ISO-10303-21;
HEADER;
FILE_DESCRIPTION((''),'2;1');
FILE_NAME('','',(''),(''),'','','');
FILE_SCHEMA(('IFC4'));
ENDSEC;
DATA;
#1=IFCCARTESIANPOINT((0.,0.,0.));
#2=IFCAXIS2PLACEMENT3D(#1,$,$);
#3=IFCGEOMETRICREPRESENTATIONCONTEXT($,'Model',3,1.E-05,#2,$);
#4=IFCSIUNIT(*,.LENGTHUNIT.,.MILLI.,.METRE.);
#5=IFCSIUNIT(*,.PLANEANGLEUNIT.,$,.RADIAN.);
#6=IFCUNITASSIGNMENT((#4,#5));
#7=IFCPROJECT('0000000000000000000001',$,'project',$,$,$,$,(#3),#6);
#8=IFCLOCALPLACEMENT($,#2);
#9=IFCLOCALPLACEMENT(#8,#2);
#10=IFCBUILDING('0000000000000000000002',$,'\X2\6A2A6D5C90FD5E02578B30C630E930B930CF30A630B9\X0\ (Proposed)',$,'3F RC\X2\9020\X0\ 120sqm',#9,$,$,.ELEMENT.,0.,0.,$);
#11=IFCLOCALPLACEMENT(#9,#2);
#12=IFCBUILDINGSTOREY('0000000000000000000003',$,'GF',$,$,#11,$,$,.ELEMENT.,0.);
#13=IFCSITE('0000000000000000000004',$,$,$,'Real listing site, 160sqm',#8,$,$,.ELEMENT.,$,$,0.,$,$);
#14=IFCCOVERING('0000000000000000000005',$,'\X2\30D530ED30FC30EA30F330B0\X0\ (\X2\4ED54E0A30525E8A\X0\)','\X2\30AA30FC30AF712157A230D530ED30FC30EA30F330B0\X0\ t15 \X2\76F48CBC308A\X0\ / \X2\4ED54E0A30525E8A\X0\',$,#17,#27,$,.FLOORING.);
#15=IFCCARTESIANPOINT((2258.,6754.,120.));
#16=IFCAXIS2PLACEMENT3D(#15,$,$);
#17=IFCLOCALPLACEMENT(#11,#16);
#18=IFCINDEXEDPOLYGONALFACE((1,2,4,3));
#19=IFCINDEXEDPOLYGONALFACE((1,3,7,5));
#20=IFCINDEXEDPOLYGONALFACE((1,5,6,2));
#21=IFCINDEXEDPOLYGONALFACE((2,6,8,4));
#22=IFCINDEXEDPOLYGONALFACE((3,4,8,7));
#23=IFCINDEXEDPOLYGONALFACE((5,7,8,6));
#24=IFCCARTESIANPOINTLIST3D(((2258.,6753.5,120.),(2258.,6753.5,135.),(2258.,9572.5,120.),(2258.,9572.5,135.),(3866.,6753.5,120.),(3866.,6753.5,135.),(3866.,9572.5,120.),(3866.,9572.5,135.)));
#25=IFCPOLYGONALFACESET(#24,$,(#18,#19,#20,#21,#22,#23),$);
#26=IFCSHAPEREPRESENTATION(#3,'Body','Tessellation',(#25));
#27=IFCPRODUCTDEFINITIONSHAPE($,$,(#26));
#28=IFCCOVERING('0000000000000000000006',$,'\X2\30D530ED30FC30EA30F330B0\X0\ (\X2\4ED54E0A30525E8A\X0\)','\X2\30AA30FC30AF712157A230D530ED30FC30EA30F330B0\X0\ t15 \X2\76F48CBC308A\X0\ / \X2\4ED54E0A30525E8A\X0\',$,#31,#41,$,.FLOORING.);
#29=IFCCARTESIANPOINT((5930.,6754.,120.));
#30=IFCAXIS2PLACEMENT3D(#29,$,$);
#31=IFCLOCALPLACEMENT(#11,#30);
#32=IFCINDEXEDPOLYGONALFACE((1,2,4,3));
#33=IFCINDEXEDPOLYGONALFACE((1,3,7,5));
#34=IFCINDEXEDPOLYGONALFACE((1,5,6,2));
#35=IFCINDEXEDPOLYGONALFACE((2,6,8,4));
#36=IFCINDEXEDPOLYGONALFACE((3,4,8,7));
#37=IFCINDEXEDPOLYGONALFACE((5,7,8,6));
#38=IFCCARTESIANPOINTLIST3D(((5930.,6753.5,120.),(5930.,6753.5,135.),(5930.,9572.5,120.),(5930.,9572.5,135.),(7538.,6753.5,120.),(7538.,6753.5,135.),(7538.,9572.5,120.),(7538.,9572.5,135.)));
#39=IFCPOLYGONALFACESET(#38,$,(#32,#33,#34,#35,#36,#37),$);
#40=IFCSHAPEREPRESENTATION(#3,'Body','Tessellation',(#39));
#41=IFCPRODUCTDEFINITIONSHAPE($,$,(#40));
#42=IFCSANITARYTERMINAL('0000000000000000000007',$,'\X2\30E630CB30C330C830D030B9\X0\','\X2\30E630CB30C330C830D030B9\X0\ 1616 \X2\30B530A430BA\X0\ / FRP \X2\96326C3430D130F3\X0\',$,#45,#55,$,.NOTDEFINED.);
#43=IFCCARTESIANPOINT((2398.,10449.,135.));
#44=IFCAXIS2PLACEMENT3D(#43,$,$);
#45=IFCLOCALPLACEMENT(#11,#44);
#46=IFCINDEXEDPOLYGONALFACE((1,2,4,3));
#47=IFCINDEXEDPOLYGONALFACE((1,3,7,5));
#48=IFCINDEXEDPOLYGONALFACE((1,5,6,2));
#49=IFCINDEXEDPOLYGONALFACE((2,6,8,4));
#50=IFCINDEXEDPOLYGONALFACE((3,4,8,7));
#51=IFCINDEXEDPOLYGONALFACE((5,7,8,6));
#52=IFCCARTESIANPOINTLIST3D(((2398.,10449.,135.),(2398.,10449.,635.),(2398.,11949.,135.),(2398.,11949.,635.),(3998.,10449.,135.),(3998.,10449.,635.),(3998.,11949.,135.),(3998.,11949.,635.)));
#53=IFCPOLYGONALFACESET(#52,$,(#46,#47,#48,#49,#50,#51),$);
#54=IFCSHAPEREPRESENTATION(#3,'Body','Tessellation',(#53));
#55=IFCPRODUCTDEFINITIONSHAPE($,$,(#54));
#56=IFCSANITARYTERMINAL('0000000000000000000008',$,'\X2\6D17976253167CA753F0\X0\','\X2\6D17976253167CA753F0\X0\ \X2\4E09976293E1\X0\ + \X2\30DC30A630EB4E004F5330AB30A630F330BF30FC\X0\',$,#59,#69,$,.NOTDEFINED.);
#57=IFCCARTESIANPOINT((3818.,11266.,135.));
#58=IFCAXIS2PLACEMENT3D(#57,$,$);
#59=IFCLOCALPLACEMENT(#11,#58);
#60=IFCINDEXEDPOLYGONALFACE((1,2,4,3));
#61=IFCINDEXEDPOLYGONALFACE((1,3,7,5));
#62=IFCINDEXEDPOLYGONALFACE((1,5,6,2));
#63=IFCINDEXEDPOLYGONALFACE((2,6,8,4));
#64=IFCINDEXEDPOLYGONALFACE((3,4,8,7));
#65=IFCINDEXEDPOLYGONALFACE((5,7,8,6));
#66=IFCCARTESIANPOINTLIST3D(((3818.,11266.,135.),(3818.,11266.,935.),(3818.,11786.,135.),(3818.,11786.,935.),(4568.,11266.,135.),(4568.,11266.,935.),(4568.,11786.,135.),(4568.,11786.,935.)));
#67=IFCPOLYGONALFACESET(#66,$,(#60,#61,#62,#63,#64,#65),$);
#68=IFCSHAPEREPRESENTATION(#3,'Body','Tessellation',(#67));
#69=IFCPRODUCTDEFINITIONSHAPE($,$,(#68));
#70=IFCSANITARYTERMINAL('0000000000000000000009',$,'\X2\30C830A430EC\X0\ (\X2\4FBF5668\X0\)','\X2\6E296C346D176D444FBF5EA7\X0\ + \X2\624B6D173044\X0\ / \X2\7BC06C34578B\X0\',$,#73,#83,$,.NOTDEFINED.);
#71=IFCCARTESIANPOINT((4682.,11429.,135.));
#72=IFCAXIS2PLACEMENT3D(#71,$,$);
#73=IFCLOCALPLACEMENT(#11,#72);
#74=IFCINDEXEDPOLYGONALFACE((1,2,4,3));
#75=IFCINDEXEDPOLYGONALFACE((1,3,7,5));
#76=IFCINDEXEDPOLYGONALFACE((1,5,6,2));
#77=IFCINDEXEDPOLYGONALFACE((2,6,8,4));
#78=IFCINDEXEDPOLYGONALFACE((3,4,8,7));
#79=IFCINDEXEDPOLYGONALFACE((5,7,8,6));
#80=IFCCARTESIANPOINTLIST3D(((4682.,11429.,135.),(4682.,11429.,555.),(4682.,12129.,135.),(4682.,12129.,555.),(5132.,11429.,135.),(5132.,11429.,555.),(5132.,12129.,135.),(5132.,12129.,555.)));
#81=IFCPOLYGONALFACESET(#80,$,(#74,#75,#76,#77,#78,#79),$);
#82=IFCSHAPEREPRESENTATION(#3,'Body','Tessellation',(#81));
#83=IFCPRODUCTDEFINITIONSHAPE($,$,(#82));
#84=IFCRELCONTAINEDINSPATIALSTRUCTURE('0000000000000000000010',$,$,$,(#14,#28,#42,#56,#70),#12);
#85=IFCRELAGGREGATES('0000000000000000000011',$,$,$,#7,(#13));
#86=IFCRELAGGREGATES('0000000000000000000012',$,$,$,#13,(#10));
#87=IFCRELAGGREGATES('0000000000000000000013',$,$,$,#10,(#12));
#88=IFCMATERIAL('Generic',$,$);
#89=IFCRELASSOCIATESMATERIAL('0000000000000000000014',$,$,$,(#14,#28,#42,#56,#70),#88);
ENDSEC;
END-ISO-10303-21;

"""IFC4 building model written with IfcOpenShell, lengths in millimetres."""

from ifc_helpers import new_model, si_unit, frame, frame_2d, origin, place, context, project, spatial, rectangle, extrude, material, element, save


model = new_model("IFC4")

# Units and contexts
model_context = context("Model", 3, precision=1e-05, world=origin())
ifc_project = project(units=[si_unit("LENGTHUNIT", "METRE", prefix="MILLI"), si_unit("PLANEANGLEUNIT", "RADIAN")], contexts=[model_context])

# Site, building, storey
site_placement = place(None, origin())
site = spatial("IfcSite", under=ifc_project, at=site_placement, ObjectType="Real listing site, 160sqm", CompositionType="ELEMENT", RefElevation=0.0)
building_placement = place(site_placement, origin())
building = spatial("IfcBuilding", under=site, at=building_placement, Name="横浜都市型テラスハウス (Proposed)", ObjectType="3F RC造 120sqm", CompositionType="ELEMENT", ElevationOfRefHeight=0.0, ElevationOfTerrain=0.0)
storey_placement = place(building_placement, origin())
storey = spatial("IfcBuildingStorey", under=building, at=storey_placement, Name="GF", CompositionType="ELEMENT", Elevation=0.0)

# Coverings
ifc_material_1 = material(Name="Generic")
covering_1_placement = place(storey_placement, frame((2258.0, 6754.0, 120.0)))
element("IfcCovering", 1, at=covering_1_placement, inside=storey, material=ifc_material_1, Name="フローリング (仕上げ床)", Description="オーク無垢フローリング t15 直貼り / 仕上げ床", PredefinedType="FLOORING", context=model_context, shape_type="SweptSolid", body=[
    extrude(rectangle(XDim=1608.0, YDim=2819.0, at=frame_2d((804.0, 1409.0))), frame((2258.0, 6754.0, 120.0)), (0.0, 0.0, 1.0), 15.0),
])
covering_2_placement = place(storey_placement, frame((5930.0, 6754.0, 120.0)))
element("IfcCovering", 2, at=covering_2_placement, inside=storey, material=ifc_material_1, Name="フローリング (仕上げ床)", Description="オーク無垢フローリング t15 直貼り / 仕上げ床", PredefinedType="FLOORING", context=model_context, shape_type="SweptSolid", body=[
    extrude(rectangle(XDim=1608.0, YDim=2819.0, at=frame_2d((804.0, 1409.0))), frame((5930.0, 6754.0, 120.0)), (0.0, 0.0, 1.0), 15.0),
])

# Sanitary terminals
sanitary_terminal_1_placement = place(storey_placement, frame((2398.0, 10449.0, 135.0)))
element("IfcSanitaryTerminal", 3, at=sanitary_terminal_1_placement, inside=storey, material=ifc_material_1, Name="ユニットバス", Description="ユニットバス 1616 サイズ / FRP 防水パン", PredefinedType="NOTDEFINED", context=model_context, shape_type="SweptSolid", body=[
    extrude(rectangle(XDim=1600.0, YDim=1500.0, at=frame_2d((800.0, 750.0))), frame((2398.0, 10449.0, 135.0)), (0.0, 0.0, 1.0), 500.0),
])
sanitary_terminal_2_placement = place(storey_placement, frame((3818.0, 11266.0, 135.0)))
element("IfcSanitaryTerminal", 4, at=sanitary_terminal_2_placement, inside=storey, material=ifc_material_1, Name="洗面化粧台", Description="洗面化粧台 三面鏡 + ボウル一体カウンター", PredefinedType="NOTDEFINED", context=model_context, shape_type="SweptSolid", body=[
    extrude(rectangle(XDim=750.0, YDim=520.0, at=frame_2d((375.0, 260.0))), frame((3818.0, 11266.0, 135.0)), (0.0, 0.0, 1.0), 800.0),
])
sanitary_terminal_3_placement = place(storey_placement, frame((4682.0, 11429.0, 135.0)))
element("IfcSanitaryTerminal", 5, at=sanitary_terminal_3_placement, inside=storey, material=ifc_material_1, Name="トイレ (便器)", Description="温水洗浄便座 + 手洗い / 節水型", PredefinedType="NOTDEFINED", context=model_context, shape_type="SweptSolid", body=[
    extrude(rectangle(XDim=450.0, YDim=700.0, at=frame_2d((225.0, 350.0))), frame((4682.0, 11429.0, 135.0)), (0.0, 0.0, 1.0), 420.0),
])

save(model, "model.ifc")
